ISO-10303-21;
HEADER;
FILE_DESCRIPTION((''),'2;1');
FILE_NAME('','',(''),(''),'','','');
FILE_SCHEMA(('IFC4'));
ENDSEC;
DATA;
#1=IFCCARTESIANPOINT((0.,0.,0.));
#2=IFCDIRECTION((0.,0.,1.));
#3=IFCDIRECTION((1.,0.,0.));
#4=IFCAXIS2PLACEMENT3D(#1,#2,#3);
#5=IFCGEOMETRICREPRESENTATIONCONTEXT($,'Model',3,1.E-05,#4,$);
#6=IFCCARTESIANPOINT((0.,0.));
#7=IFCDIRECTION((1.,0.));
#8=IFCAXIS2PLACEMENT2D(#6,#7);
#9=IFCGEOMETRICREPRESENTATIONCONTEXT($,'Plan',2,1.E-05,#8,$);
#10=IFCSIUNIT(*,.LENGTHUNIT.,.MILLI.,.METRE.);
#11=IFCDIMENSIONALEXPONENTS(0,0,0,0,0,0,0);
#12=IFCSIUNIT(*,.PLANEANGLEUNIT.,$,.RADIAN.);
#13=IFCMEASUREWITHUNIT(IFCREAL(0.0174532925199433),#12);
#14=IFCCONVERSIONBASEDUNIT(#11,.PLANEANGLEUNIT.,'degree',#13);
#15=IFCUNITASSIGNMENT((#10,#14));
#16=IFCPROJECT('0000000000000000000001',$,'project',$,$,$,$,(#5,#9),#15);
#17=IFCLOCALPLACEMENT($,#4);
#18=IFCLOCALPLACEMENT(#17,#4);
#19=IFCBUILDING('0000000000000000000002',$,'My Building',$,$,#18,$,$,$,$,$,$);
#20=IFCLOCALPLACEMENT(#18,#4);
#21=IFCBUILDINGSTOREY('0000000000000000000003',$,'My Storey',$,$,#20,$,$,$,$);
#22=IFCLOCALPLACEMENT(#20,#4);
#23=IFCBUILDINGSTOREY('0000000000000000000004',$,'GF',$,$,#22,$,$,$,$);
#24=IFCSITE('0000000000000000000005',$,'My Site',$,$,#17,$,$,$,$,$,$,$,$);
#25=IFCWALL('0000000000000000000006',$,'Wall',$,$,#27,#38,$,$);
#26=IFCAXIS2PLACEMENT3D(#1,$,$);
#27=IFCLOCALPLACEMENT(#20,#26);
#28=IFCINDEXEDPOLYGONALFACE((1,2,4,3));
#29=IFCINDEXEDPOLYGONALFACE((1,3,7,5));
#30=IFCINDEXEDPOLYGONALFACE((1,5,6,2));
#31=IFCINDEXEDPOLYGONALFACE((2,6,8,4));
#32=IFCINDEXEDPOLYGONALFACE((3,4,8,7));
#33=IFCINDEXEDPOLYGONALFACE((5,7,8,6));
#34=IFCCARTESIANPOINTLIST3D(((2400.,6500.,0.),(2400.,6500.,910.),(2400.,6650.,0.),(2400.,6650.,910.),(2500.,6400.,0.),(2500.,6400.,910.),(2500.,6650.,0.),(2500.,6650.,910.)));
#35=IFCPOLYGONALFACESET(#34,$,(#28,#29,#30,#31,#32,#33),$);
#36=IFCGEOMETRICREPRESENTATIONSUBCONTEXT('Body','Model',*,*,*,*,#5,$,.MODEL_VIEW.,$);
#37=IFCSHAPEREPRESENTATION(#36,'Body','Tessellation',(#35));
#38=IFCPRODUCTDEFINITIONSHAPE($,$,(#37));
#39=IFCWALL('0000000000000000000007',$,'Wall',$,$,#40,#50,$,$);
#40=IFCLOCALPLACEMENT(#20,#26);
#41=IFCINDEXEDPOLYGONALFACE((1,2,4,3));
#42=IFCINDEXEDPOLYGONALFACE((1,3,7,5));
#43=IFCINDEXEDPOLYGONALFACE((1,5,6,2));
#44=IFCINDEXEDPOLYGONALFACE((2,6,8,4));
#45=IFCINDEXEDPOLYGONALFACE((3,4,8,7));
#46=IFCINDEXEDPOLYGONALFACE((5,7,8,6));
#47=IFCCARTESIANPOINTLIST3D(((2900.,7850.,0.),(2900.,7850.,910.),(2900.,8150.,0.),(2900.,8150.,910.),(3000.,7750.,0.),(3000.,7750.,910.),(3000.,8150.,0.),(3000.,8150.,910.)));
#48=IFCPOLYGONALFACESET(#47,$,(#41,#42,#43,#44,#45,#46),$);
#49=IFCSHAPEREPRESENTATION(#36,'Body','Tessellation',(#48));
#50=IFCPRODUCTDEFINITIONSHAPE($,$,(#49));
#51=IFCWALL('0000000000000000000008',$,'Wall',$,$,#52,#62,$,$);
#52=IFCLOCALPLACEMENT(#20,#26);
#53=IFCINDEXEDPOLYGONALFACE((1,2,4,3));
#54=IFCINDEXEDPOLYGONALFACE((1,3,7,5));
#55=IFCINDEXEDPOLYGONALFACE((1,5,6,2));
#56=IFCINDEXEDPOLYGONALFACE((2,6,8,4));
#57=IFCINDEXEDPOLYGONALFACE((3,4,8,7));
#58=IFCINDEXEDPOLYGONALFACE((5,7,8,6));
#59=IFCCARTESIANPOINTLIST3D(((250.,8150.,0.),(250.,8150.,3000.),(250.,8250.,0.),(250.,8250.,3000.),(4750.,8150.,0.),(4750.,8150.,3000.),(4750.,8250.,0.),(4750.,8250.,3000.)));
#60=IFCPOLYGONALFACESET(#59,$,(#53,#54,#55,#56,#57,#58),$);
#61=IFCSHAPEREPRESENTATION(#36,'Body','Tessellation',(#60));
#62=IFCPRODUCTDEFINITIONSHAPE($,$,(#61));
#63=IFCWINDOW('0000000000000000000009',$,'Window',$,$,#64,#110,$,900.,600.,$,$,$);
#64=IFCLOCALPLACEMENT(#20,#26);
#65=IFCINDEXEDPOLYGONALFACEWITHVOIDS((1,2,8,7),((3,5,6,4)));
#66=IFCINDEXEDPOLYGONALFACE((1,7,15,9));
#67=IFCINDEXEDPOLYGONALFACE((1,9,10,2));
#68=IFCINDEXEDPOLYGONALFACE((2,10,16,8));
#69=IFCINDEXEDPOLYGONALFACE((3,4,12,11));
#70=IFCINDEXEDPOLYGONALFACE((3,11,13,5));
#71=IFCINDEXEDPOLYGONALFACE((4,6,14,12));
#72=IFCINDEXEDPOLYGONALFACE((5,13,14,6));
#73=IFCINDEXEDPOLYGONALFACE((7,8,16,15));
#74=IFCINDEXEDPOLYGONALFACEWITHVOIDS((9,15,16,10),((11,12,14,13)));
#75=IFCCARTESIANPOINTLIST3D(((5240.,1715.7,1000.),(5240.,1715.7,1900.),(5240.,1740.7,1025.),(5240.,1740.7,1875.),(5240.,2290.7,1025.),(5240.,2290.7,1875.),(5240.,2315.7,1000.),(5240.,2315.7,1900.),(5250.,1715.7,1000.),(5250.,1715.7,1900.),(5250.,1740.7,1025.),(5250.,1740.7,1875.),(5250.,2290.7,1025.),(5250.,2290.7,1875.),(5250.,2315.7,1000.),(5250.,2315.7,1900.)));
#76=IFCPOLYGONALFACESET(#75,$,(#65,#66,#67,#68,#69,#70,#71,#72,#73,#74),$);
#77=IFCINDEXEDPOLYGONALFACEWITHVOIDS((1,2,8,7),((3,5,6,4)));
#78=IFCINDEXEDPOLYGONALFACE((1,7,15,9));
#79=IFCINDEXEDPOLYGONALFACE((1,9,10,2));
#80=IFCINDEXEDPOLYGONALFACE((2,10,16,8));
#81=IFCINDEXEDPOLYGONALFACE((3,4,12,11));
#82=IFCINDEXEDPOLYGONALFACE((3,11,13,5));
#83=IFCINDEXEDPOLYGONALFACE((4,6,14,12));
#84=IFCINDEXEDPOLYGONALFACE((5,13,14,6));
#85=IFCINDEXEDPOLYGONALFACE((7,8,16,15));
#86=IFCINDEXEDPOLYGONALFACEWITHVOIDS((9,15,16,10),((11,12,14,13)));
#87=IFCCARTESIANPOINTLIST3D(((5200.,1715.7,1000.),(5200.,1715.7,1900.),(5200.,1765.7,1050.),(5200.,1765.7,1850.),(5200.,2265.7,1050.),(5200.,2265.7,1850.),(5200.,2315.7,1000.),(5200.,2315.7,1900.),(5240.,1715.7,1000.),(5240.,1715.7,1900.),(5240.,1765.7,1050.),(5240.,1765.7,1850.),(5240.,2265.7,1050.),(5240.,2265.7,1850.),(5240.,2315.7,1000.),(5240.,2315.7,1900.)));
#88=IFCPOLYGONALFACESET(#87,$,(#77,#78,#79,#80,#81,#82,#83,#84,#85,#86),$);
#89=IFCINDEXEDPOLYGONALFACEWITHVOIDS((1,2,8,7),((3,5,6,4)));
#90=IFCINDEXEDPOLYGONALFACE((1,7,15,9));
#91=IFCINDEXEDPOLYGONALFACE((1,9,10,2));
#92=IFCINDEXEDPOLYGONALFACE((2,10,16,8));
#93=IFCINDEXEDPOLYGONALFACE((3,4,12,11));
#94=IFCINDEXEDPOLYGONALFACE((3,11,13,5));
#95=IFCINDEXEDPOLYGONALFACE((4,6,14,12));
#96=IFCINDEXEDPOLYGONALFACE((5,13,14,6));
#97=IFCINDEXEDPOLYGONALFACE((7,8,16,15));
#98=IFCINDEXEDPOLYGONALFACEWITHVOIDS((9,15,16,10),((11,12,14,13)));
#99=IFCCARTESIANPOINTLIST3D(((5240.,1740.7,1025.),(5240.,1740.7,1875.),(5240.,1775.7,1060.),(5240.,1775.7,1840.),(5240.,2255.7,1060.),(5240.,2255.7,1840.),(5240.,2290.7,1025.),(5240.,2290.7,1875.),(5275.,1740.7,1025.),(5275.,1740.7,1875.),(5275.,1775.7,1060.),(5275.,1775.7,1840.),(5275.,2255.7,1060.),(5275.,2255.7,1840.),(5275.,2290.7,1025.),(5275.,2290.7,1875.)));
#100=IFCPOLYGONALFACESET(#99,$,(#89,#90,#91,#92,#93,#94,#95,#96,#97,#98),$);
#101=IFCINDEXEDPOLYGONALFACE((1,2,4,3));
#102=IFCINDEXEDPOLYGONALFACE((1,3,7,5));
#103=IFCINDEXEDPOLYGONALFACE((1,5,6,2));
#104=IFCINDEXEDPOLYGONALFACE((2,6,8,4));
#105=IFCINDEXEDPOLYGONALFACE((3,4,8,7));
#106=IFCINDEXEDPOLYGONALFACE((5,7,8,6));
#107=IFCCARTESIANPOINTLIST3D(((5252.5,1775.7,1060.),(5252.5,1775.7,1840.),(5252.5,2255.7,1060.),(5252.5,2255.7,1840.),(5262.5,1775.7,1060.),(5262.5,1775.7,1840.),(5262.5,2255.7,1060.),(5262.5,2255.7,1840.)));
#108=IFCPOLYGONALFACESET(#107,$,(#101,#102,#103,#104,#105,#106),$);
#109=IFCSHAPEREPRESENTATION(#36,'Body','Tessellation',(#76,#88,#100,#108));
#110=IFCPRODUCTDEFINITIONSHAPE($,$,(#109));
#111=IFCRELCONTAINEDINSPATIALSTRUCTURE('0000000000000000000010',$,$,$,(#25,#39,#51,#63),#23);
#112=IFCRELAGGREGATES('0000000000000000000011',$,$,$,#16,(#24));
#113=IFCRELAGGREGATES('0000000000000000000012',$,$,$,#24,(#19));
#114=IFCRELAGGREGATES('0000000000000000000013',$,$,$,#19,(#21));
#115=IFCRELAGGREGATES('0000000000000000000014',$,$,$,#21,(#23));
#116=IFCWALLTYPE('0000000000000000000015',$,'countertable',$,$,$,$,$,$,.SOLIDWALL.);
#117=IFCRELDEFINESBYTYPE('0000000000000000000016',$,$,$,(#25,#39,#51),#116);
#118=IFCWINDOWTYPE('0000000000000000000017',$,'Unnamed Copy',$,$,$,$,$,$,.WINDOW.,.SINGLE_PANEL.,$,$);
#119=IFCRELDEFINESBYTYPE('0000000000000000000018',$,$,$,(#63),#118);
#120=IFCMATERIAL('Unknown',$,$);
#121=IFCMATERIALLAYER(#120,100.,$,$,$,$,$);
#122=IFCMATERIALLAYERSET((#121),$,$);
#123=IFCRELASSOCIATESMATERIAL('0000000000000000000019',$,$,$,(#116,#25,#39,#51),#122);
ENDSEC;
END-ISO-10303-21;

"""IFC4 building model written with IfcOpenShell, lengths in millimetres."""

from ifc_helpers import new_model, entity, si_unit, converted_unit, frame, origin_with_axes, origin_2d_with_axis, place, context, subcontext, project, spatial, line, indexed_curve, outline, extrude, shape, source, transform, mapped, material, layer, layer_set, layer_usage, type_object, type_shapes, element, save


model = new_model("IFC4")

# Units and contexts
model_context = context("Model", 3, precision=1e-05, world=origin_with_axes())
plan_context = context("Plan", 2, precision=1e-05, world=origin_2d_with_axis())
body_context_1 = subcontext(model_context, "Body", "Model", "MODEL_VIEW")
body_context_2 = subcontext(plan_context, "Body", "Plan", "PLAN_VIEW")
ifc_project = project(units=[si_unit("LENGTHUNIT", "METRE", prefix="MILLI"), converted_unit("PLANEANGLEUNIT", "degree", entity("IfcReal", 0.0174532925199433), si_unit("PLANEANGLEUNIT", "RADIAN"), dimensions=[0, 0, 0, 0, 0, 0, 0])], contexts=[model_context, plan_context])

# Site, building, storeys
site_placement = place(None, origin_with_axes())
site = spatial("IfcSite", under=ifc_project, at=site_placement, Name="My Site")
building_placement = place(site_placement, origin_with_axes())
building = spatial("IfcBuilding", under=site, at=building_placement, Name="My Building")
storey_1_placement = place(building_placement, origin_with_axes())
storey_1 = spatial("IfcBuildingStorey", under=building, at=storey_1_placement, Name="My Storey")
storey_2_placement = place(storey_1_placement, origin_with_axes())
storey_2 = spatial("IfcBuildingStorey", under=storey_1, at=storey_2_placement, Name="GF")

# Shared definitions
ifc_material = material(Name="Unknown")

# Shared definitions
window_type_1 = type_object("IfcWindowType", Name="Unnamed Copy", PartitioningType="SINGLE_PANEL", PredefinedType="WINDOW")
shared_shape_1 = source(origin_with_axes(), body_context_1, "Body", "SweptSolid", [
    extrude(outline(indexed_curve([(0.0, 0.0), (600.0, 0.0), (600.0, 900.0), (0.0, 900.0)], segments=[line(1, 2, 3, 4, 1)]), holes=[indexed_curve([(25.0, 25.0), (575.0, 25.0), (575.0, 875.0), (25.0, 875.0)], segments=[line(1, 2, 3, 4, 1)])]), frame((0.0, 90.0, 0.0), z_axis=(0.0, -1.0, 0.0), x_axis=(1.0, 0.0, 0.0)), (0.0, 0.0, -1.0), 10.0),
    extrude(outline(indexed_curve([(0.0, 0.0), (600.0, 0.0), (600.0, 900.0), (0.0, 900.0)], segments=[line(1, 2, 3, 4, 1)]), holes=[indexed_curve([(50.0, 50.0), (550.0, 50.0), (550.0, 850.0), (50.0, 850.0)], segments=[line(1, 2, 3, 4, 1)])]), frame((0.0, 50.0, 0.0), z_axis=(0.0, -1.0, 0.0), x_axis=(1.0, 0.0, 0.0)), (0.0, 0.0, -1.0), 40.0),
    extrude(outline(indexed_curve([(0.0, 0.0), (550.0, 0.0), (550.0, 850.0), (0.0, 850.0)], segments=[line(1, 2, 3, 4, 1)]), holes=[indexed_curve([(35.0, 35.0), (515.0, 35.0), (515.0, 815.0), (35.0, 815.0)], segments=[line(1, 2, 3, 4, 1)])]), frame((25.0, 90.0, 25.0), z_axis=(0.0, -1.0, 0.0), x_axis=(1.0, 0.0, 0.0)), (0.0, 0.0, -1.0), 35.0),
    extrude(outline(indexed_curve([(35.0, 35.0), (515.0, 35.0), (515.0, 815.0), (35.0, 815.0)], segments=[line(1, 2, 3, 4, 1)])), frame((25.0, 102.5, 25.0), z_axis=(0.0, -1.0, 0.0), x_axis=(1.0, 0.0, 0.0)), (0.0, 0.0, -1.0), 10.0),
])
shared_shape_2 = source(origin_with_axes(), body_context_2, "Body", "Curve2D", [
    entity("IfcIndexedPolyCurve", entity("IfcCartesianPointList2D", [[50.0, 50.0], [550.0, 50.0]])),
    entity("IfcIndexedPolyCurve", entity("IfcCartesianPointList2D", [[0.0, 100.0], [25.0, 100.0], [25.0, 90.0], [50.0, 90.0], [50.0, 50.0], [0.0, 50.0]]), [entity("IfcLineIndex", [1, 2, 3, 4, 5, 6, 1])]),
    entity("IfcIndexedPolyCurve", entity("IfcCartesianPointList2D", [[600.0, 100.0], [575.0, 100.0], [575.0, 90.0], [550.0, 90.0], [550.0, 50.0], [600.0, 50.0]]), [entity("IfcLineIndex", [1, 2, 3, 4, 5, 6, 1])]),
    entity("IfcIndexedPolyCurve", entity("IfcCartesianPointList2D", [[25.0, 90.0], [60.0, 90.0], [60.0, 125.0], [25.0, 125.0]]), [entity("IfcLineIndex", [1, 2, 3, 4, 1])]),
    entity("IfcIndexedPolyCurve", entity("IfcCartesianPointList2D", [[575.0, 90.0], [540.0, 90.0], [540.0, 125.0], [575.0, 125.0]]), [entity("IfcLineIndex", [1, 2, 3, 4, 1])]),
    entity("IfcIndexedPolyCurve", entity("IfcCartesianPointList2D", [[60.0, 90.0], [540.0, 90.0]])),
    entity("IfcIndexedPolyCurve", entity("IfcCartesianPointList2D", [[60.0, 125.0], [540.0, 125.0]])),
    entity("IfcIndexedPolyCurve", entity("IfcCartesianPointList2D", [[60.0, 107.5], [540.0, 107.5]])),
])
type_shapes(window_type_1, [shared_shape_1, shared_shape_2])

# Walls
ifc_layer_1 = layer(ifc_material, 100.0)
ifc_layer_set_1 = layer_set([ifc_layer_1])
wall_type_1 = type_object("IfcWallType", Name="countertable", PredefinedType="SOLIDWALL", material=ifc_layer_set_1)
ifc_layer_usage_1 = layer_usage(ifc_layer_set_1, "AXIS2", "POSITIVE", 0.0)
wall_1_placement = place(storey_2_placement, frame((2500.0, 6400.0, 0.0), z_axis=(0.0, 0.0, 1.0), x_axis=(0.0, 1.0, 0.0)))
element("IfcWall", 1, at=wall_1_placement, inside=storey_2, type_object=wall_type_1, material=ifc_layer_usage_1, Name="Wall", context=body_context_1, shape_type="SweptSolid", body=[
    extrude(outline(indexed_curve([(0.0, 0.0), (100.0, 100.0), (250.0, 100.0), (250.0, 0.0)], segments=[line(1, 2, 3, 4, 1)])), origin_with_axes(), (0.0, 0.0, 1.0), 910.0),
])
ifc_layer_usage_2 = layer_usage(ifc_layer_set_1, "AXIS2", "POSITIVE", 0.0)
wall_2_placement = place(storey_2_placement, frame((3000.0, 7750.0, 0.0), z_axis=(0.0, 0.0, 1.0), x_axis=(0.0, 1.0, 0.0)))
element("IfcWall", 2, at=wall_2_placement, inside=storey_2, type_object=wall_type_1, material=ifc_layer_usage_2, Name="Wall", context=body_context_1, shape_type="SweptSolid", body=[
    extrude(outline(indexed_curve([(0.0, 0.0), (100.0, 100.0), (400.0, 100.0), (400.0, 0.0)], segments=[line(1, 2, 3, 4, 1)])), origin_with_axes(), (0.0, 0.0, 1.0), 910.0),
])
ifc_layer_usage_3 = layer_usage(ifc_layer_set_1, "AXIS2", "POSITIVE", 0.0)
wall_3_placement = place(storey_2_placement, frame((250.0, 8150.0, 0.0), z_axis=(0.0, 0.0, 1.0), x_axis=(1.0, 0.0, 0.0)))
element("IfcWall", 3, at=wall_3_placement, inside=storey_2, type_object=wall_type_1, material=ifc_layer_usage_3, Name="Wall", context=body_context_1, shape_type="SweptSolid", body=[
    extrude(outline(indexed_curve([(0.0, 0.0), (0.0, 100.0), (4500.0, 100.0), (4500.0, 0.0)], segments=[line(1, 2, 3, 4, 1)])), origin_with_axes(), (0.0, 0.0, 1.0), 3000.0),
])

# Window
placement_1 = place(storey_2_placement, frame((5150.0, 3750.0, 0.0), z_axis=(0.0, 0.0, 1.0), x_axis=(0.0, -1.0, 0.0)))
placement_2 = place(placement_1, frame((1434.3, 0.0, 1000.0), z_axis=(0.0, 0.0, 1.0), x_axis=(1.0, 0.0, 0.0)))
window_1_placement = place(placement_2, frame((0.0, 0.0, 0.0), z_axis=(0.0, 0.0, 1.0), x_axis=(1.0, 0.0, 0.0)))
element("IfcWindow", 4, at=window_1_placement, inside=storey_2, type_object=window_type_1, Name="Window", OverallHeight=900.0, OverallWidth=600.0, shapes=[
    shape(body_context_1, "Body", "MappedRepresentation", [mapped(shared_shape_1, transform((0.0, 0.0, 0.0), x_axis=(1.0, 0.0, 0.0), y_axis=(0.0, 1.0, 0.0), z_axis=(0.0, 0.0, 1.0), scale=1.0))]),
    shape(body_context_2, "Body", "MappedRepresentation", [mapped(shared_shape_2, transform((0.0, 0.0, 0.0), x_axis=(1.0, 0.0, 0.0), y_axis=(0.0, 1.0, 0.0), z_axis=(0.0, 0.0, 1.0), scale=1.0))]),
])

save(model, "model.ifc")
